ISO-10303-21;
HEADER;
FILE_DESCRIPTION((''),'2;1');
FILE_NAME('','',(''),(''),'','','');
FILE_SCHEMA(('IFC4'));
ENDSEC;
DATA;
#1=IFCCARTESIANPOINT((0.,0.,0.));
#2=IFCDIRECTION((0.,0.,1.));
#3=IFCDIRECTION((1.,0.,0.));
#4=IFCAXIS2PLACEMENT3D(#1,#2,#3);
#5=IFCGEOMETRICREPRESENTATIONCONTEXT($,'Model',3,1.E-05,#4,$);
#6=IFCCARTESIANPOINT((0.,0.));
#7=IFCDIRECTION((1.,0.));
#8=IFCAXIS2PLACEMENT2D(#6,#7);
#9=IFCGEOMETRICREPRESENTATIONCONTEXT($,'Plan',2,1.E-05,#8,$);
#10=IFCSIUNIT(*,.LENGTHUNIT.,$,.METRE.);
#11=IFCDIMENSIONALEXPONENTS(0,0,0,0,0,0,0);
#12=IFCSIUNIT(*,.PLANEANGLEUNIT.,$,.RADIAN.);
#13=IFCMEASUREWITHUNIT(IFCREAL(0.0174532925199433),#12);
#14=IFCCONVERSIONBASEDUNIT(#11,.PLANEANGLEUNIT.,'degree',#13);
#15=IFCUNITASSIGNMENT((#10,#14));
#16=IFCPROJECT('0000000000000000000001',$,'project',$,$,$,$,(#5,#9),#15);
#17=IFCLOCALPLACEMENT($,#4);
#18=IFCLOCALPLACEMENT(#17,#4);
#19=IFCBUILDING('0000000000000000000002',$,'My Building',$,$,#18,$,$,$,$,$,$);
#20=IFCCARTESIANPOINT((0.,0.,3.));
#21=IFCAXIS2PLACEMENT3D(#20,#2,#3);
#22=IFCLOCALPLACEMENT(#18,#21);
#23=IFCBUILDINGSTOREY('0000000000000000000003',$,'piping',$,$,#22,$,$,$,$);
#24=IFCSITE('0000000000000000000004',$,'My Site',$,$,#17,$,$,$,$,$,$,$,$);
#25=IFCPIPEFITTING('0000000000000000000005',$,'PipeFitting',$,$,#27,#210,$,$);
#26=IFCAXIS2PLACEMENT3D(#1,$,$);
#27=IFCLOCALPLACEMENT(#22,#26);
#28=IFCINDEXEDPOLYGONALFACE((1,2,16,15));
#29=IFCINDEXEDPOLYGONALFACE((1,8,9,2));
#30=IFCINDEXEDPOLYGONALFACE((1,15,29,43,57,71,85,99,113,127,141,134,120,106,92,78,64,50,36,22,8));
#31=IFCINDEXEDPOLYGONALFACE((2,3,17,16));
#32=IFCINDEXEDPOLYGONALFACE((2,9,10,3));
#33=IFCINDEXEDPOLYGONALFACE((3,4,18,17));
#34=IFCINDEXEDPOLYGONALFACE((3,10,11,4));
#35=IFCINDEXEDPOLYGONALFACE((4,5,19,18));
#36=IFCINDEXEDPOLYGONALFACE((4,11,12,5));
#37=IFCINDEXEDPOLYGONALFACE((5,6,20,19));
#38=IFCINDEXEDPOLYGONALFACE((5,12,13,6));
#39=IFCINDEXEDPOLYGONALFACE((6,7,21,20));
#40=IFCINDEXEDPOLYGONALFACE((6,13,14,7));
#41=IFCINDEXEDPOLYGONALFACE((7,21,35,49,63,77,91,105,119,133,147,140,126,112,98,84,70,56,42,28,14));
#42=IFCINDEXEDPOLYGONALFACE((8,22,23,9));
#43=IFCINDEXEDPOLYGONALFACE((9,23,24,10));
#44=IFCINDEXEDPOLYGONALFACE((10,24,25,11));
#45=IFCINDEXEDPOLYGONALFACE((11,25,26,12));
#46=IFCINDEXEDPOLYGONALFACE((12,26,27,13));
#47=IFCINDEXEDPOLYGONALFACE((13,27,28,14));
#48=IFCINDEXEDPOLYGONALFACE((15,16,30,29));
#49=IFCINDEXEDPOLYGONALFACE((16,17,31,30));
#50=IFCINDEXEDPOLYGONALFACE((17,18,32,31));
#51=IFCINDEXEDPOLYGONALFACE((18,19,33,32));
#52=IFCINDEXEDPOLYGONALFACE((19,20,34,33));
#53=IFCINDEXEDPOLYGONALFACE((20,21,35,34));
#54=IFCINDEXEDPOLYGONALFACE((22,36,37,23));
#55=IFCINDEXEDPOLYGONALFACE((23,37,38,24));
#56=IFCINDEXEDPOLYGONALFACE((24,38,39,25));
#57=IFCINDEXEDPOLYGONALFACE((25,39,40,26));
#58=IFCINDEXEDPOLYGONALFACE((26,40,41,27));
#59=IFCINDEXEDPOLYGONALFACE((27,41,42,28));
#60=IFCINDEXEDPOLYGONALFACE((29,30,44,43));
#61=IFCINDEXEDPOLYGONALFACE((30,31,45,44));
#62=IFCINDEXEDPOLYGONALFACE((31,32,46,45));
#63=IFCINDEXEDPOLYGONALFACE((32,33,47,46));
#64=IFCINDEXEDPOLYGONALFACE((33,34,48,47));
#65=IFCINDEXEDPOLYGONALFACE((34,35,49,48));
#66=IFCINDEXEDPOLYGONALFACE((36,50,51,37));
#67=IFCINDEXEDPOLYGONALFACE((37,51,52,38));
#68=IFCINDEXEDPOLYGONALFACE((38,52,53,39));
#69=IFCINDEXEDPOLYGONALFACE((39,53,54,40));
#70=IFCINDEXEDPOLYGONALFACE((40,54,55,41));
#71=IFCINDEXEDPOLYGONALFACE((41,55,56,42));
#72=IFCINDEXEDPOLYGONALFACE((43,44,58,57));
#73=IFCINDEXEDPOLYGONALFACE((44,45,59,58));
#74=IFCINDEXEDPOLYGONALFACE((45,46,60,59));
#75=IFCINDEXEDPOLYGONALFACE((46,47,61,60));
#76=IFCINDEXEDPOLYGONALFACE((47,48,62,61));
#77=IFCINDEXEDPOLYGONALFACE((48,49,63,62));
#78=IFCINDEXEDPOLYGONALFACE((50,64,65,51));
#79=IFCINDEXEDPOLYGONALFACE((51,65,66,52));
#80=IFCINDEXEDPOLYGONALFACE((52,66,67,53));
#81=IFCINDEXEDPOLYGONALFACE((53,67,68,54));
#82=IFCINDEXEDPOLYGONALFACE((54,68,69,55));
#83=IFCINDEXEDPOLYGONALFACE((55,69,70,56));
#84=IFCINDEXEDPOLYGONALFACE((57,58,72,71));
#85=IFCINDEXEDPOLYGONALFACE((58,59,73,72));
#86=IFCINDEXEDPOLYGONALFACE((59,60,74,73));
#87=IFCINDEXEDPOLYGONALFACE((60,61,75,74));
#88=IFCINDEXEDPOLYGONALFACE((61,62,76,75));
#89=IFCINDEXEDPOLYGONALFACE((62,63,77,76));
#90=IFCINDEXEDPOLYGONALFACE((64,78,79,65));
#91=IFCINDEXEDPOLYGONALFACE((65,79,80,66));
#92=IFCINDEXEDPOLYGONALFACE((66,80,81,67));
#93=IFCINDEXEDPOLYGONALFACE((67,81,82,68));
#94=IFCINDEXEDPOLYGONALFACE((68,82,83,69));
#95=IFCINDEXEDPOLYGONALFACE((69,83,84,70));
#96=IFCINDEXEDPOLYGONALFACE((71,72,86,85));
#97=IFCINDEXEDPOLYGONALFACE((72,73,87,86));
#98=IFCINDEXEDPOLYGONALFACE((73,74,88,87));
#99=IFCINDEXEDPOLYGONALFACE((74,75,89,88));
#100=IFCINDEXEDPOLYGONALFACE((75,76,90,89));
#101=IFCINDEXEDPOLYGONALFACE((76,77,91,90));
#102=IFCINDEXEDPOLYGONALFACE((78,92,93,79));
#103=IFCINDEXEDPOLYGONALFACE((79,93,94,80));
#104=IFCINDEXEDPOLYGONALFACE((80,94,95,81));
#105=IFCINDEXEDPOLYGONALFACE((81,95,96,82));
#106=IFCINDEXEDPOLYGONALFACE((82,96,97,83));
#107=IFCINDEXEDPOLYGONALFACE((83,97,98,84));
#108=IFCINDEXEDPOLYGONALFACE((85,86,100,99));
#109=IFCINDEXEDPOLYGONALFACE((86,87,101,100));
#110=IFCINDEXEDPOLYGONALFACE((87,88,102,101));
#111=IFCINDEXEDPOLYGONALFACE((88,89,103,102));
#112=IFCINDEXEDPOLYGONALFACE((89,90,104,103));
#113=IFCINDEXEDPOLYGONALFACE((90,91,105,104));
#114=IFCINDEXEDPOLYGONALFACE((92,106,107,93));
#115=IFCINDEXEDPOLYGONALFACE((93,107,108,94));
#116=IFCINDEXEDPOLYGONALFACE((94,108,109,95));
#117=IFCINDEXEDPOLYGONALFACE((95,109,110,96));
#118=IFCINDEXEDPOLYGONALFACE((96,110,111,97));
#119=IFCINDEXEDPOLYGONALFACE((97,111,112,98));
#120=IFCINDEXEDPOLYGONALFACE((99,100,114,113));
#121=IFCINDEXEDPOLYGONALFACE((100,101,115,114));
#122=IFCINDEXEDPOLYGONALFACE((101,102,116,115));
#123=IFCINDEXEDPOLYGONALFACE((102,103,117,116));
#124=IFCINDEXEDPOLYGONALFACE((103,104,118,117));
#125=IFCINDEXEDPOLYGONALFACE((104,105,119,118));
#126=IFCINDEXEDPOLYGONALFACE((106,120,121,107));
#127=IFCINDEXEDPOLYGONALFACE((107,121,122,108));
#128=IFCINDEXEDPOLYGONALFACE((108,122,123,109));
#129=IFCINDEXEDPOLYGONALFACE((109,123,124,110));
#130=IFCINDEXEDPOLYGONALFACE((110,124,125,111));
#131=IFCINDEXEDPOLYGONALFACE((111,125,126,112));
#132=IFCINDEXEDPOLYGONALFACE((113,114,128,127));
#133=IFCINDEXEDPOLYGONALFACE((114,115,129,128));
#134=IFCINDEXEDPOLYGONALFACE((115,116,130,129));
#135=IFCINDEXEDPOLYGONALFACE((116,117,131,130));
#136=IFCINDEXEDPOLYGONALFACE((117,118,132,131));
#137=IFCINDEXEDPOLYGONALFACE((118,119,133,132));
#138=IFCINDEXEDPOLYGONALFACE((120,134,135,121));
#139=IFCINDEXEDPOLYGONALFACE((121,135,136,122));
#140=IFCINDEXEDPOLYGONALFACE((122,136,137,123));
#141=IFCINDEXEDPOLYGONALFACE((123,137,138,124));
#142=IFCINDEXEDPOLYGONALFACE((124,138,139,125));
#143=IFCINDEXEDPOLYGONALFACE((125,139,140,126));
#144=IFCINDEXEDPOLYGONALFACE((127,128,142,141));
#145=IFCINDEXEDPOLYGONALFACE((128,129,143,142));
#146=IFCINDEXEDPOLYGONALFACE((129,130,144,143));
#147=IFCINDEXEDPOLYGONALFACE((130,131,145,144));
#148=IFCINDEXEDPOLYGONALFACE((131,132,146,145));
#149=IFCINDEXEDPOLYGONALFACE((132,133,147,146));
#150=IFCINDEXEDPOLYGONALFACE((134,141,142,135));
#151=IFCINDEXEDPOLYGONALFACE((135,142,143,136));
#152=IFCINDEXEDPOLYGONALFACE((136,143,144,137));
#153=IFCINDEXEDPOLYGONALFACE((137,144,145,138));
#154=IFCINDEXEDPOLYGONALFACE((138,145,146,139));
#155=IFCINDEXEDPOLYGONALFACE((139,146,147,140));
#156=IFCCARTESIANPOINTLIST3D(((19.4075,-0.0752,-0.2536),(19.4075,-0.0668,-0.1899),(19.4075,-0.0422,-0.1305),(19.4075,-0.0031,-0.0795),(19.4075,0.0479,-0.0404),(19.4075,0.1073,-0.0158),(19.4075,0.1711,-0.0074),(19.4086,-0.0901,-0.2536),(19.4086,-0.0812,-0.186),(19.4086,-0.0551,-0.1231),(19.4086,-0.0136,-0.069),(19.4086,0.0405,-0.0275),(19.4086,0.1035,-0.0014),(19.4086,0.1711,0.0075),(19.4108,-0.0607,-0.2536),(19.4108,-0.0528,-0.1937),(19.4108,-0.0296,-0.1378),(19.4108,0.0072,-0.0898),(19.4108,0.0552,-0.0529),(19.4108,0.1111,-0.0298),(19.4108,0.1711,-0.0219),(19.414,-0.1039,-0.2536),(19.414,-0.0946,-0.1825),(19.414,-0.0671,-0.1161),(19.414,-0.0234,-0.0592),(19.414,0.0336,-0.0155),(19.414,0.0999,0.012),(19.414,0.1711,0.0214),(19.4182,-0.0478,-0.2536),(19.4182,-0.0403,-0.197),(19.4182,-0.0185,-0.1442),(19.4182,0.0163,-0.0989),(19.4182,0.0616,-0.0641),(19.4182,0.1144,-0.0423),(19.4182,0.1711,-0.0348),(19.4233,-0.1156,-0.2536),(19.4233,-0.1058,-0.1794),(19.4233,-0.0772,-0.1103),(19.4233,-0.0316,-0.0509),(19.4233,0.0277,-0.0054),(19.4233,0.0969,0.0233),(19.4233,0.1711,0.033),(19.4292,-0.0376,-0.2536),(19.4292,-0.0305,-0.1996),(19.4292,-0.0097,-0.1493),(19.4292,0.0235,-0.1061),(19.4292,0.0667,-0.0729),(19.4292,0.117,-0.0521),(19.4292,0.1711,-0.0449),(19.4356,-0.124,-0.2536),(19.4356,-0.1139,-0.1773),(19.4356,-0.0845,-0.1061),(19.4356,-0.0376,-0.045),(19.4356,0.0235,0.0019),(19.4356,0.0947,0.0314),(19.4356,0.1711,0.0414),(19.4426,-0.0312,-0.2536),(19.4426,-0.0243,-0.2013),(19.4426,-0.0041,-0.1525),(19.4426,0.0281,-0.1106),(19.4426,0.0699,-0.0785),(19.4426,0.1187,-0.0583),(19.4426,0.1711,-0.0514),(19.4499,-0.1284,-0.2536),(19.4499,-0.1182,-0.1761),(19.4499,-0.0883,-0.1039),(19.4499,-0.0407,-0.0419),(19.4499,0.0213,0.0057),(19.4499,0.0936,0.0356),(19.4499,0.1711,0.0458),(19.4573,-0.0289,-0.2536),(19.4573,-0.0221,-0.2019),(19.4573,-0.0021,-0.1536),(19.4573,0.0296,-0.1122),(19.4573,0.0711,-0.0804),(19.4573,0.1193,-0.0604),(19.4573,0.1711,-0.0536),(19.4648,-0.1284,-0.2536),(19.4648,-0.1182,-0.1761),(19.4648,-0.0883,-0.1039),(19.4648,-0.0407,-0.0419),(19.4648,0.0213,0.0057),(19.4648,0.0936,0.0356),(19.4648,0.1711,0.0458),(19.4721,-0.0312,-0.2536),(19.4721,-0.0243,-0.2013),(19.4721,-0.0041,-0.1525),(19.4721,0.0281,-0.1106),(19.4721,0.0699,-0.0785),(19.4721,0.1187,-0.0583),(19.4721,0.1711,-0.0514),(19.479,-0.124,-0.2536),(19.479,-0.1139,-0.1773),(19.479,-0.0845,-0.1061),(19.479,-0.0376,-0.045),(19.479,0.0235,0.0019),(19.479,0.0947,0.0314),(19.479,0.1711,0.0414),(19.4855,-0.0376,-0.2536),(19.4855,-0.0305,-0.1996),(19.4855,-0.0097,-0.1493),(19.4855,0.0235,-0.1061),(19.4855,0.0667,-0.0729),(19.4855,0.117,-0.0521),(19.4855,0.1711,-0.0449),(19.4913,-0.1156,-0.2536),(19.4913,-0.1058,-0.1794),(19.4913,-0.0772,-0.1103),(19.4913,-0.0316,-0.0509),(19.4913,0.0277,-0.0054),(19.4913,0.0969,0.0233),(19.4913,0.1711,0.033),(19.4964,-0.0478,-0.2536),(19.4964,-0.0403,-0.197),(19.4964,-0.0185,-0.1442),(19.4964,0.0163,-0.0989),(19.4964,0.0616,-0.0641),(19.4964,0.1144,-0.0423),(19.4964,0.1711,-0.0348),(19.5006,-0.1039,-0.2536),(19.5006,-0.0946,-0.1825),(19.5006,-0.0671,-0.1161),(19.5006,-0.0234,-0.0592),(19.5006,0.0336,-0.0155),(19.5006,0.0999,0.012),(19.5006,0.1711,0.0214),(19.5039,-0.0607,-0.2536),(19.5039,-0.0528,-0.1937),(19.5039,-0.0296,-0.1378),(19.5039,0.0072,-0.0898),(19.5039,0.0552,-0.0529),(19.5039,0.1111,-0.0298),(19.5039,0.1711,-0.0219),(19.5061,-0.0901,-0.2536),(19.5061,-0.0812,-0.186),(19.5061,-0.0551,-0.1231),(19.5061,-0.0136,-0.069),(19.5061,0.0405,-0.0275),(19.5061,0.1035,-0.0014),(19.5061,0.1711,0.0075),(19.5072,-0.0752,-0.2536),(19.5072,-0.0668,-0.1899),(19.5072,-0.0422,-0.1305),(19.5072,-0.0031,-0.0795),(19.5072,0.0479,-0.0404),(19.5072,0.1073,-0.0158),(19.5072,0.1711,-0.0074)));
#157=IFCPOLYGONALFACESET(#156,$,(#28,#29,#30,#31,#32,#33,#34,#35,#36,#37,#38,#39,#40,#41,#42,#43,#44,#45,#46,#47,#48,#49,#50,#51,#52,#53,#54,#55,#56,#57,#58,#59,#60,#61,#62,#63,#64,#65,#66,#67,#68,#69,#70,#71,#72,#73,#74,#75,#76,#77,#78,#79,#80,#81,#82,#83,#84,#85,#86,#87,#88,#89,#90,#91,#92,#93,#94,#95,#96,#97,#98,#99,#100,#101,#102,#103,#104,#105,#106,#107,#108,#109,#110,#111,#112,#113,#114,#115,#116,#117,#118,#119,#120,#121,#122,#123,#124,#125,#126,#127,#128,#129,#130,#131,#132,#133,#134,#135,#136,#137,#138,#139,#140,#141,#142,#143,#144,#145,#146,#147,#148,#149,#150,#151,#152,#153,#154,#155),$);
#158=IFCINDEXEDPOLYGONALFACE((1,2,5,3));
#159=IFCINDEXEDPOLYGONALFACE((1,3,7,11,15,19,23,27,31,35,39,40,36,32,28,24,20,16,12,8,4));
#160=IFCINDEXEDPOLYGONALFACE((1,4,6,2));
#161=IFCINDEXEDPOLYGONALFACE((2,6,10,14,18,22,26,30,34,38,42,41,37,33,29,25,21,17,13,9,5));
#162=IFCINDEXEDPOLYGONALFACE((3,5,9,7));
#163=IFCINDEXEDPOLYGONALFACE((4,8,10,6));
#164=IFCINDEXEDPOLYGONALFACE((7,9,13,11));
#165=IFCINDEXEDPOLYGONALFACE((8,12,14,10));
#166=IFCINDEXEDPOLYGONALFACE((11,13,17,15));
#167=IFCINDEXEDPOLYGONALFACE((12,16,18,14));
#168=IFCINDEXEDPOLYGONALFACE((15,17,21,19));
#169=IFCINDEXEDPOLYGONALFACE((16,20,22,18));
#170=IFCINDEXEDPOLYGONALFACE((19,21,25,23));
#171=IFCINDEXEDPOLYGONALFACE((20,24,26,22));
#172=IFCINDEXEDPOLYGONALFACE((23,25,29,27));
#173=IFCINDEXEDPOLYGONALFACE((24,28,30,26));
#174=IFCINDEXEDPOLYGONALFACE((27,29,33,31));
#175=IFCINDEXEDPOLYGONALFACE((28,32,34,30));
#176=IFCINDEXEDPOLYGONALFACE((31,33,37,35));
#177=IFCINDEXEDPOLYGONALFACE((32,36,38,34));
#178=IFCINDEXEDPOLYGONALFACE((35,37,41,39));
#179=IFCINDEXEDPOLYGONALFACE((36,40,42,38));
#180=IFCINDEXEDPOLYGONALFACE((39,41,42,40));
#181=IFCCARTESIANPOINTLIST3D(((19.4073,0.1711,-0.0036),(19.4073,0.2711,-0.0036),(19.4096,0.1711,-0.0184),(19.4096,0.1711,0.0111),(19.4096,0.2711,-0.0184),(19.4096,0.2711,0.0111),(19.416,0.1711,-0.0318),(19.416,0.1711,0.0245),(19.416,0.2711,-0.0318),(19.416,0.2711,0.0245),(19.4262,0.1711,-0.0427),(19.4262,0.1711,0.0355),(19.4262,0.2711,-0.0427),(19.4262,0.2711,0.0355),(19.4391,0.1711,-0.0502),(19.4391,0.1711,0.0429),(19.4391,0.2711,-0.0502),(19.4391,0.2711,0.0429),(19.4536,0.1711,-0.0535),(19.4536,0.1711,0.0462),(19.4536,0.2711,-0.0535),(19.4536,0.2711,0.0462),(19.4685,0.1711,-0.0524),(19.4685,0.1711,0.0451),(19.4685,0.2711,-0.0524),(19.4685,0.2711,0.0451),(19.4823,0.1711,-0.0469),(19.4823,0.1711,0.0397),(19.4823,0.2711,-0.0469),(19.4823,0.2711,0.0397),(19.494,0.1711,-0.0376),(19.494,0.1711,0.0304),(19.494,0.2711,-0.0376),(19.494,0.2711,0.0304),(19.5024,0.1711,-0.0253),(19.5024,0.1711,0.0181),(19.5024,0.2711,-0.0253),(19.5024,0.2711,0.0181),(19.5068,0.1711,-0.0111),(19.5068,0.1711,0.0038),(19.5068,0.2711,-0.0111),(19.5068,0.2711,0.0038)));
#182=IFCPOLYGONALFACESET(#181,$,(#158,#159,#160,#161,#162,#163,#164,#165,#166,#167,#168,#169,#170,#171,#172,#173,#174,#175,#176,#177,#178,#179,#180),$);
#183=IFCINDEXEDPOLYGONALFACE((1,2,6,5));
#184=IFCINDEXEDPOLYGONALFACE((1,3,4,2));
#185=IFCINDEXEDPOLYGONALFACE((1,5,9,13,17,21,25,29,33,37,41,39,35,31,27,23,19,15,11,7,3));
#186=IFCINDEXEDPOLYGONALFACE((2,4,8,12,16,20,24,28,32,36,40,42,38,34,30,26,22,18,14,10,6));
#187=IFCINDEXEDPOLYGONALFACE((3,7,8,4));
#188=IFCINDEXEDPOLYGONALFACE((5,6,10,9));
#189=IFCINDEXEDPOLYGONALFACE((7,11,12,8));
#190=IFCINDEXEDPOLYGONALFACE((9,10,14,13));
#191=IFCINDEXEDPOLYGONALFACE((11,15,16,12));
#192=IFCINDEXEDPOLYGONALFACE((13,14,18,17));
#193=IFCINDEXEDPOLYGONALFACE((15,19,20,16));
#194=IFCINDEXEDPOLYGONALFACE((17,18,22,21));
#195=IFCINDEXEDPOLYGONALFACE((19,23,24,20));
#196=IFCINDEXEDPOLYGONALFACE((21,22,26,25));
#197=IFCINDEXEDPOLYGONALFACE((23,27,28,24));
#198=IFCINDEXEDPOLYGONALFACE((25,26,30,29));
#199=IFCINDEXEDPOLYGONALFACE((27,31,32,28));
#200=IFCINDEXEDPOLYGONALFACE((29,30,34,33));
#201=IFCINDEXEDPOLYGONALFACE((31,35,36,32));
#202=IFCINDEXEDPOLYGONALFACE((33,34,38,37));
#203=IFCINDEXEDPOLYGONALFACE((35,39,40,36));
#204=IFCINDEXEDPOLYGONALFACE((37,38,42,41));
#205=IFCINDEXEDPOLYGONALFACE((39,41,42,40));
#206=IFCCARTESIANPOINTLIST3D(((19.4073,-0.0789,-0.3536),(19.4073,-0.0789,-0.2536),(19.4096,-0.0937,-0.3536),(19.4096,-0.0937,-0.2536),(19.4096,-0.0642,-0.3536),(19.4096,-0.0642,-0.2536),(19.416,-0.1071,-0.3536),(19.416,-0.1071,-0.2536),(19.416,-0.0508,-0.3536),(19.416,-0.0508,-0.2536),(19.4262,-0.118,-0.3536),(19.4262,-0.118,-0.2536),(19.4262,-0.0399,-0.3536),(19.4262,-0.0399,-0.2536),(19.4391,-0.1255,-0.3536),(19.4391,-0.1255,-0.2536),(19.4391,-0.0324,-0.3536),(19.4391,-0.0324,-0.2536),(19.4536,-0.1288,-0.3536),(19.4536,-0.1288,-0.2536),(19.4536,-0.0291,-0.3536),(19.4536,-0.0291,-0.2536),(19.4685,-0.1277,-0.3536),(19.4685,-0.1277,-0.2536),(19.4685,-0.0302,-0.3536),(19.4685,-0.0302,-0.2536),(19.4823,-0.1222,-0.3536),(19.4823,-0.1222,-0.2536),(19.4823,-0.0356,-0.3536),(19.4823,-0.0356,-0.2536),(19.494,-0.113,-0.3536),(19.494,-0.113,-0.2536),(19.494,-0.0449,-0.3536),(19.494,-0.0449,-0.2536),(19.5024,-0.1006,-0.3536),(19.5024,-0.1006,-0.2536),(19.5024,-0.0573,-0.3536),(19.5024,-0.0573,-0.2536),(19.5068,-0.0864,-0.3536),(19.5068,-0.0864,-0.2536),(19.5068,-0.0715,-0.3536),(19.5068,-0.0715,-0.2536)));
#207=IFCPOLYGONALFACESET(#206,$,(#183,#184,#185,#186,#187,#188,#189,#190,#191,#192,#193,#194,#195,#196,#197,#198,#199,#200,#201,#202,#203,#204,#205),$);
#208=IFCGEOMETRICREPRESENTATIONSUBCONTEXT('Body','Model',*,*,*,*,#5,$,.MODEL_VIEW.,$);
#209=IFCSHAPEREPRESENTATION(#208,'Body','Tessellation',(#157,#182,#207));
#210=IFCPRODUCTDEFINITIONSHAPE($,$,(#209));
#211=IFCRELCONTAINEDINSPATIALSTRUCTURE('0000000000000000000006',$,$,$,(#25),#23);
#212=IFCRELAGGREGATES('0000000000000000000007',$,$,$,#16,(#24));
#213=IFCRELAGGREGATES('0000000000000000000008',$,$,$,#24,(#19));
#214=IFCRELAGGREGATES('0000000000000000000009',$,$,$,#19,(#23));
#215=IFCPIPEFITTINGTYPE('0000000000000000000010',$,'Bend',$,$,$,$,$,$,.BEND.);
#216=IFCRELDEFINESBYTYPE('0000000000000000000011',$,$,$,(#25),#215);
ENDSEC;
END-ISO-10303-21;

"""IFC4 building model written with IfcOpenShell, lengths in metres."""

from ifc_helpers import new_model, entity, si_unit, converted_unit, frame, origin_with_axes, origin_2d_with_axis, place, context, subcontext, project, spatial, circle, extrude, source, transform, mapped, type_object, type_shapes, element, save


model = new_model("IFC4")

# Units and contexts
model_context = context("Model", 3, precision=1e-05, world=origin_with_axes())
plan_context = context("Plan", 2, precision=1e-05, world=origin_2d_with_axis())
body_context = subcontext(model_context, "Body", "Model", "MODEL_VIEW")
ifc_project = project(units=[si_unit("LENGTHUNIT", "METRE"), converted_unit("PLANEANGLEUNIT", "degree", entity("IfcReal", 0.0174532925199433), si_unit("PLANEANGLEUNIT", "RADIAN"), dimensions=[0, 0, 0, 0, 0, 0, 0])], contexts=[model_context, plan_context])

# Site, building, storey
site_placement = place(None, origin_with_axes())
site = spatial("IfcSite", under=ifc_project, at=site_placement, Name="My Site")
building_placement = place(site_placement, origin_with_axes())
building = spatial("IfcBuilding", under=site, at=building_placement, Name="My Building")
storey_placement = place(building_placement, frame((0.0, 0.0, 3.0), z_axis=(0.0, 0.0, 1.0), x_axis=(1.0, 0.0, 0.0)))
storey = spatial("IfcBuildingStorey", under=building, at=storey_placement, Name="piping")

# Pipe fitting
pipe_fitting_type = type_object("IfcPipeFittingType", Name="Bend", PredefinedType="BEND")
shared_shape = source(origin_with_axes(), body_context, "Body", "SolidModel", [
    entity("IfcSweptDiskSolid", entity("IfcIndexedPolyCurve", entity("IfcCartesianPointList3D", [[0.0, 0.0, -0.1], [0.0, -0.0732, -0.2768], [0.0, -0.25, -0.35]]), [entity("IfcArcIndex", [1, 2, 3])]), 0.05),
    extrude(circle(Radius=0.05), origin_with_axes(), (0.0, 0.0, -1.0), 0.1),
    extrude(circle(Radius=0.05), frame((0.0, -0.25, -0.35), z_axis=(0.0, -1.0, 0.0), x_axis=(1.0, 0.0, 0.0)), (0.0, 0.0, 1.0), 0.1),
])
type_shapes(pipe_fitting_type, [shared_shape])
for number, where, z_axis, x_axis, name in (
    (1, (19.4573, 0.2711, -0.0036), (0.0, 1.0, 0.0), (-1.0, 0.0, 0.0), "PipeFitting"),
):
    element("IfcPipeFitting", number, at=place(storey_placement, frame(where, z_axis=z_axis, x_axis=x_axis)), inside=storey, type_object=pipe_fitting_type, Name=name, context=body_context, shape_type="MappedRepresentation", body=[
        mapped(shared_shape, transform((0.0, 0.0, 0.0), x_axis=(1.0, 0.0, 0.0), y_axis=(0.0, 1.0, 0.0), z_axis=(0.0, 0.0, 1.0), scale=1.0)),
    ])

save(model, "model.ifc")
